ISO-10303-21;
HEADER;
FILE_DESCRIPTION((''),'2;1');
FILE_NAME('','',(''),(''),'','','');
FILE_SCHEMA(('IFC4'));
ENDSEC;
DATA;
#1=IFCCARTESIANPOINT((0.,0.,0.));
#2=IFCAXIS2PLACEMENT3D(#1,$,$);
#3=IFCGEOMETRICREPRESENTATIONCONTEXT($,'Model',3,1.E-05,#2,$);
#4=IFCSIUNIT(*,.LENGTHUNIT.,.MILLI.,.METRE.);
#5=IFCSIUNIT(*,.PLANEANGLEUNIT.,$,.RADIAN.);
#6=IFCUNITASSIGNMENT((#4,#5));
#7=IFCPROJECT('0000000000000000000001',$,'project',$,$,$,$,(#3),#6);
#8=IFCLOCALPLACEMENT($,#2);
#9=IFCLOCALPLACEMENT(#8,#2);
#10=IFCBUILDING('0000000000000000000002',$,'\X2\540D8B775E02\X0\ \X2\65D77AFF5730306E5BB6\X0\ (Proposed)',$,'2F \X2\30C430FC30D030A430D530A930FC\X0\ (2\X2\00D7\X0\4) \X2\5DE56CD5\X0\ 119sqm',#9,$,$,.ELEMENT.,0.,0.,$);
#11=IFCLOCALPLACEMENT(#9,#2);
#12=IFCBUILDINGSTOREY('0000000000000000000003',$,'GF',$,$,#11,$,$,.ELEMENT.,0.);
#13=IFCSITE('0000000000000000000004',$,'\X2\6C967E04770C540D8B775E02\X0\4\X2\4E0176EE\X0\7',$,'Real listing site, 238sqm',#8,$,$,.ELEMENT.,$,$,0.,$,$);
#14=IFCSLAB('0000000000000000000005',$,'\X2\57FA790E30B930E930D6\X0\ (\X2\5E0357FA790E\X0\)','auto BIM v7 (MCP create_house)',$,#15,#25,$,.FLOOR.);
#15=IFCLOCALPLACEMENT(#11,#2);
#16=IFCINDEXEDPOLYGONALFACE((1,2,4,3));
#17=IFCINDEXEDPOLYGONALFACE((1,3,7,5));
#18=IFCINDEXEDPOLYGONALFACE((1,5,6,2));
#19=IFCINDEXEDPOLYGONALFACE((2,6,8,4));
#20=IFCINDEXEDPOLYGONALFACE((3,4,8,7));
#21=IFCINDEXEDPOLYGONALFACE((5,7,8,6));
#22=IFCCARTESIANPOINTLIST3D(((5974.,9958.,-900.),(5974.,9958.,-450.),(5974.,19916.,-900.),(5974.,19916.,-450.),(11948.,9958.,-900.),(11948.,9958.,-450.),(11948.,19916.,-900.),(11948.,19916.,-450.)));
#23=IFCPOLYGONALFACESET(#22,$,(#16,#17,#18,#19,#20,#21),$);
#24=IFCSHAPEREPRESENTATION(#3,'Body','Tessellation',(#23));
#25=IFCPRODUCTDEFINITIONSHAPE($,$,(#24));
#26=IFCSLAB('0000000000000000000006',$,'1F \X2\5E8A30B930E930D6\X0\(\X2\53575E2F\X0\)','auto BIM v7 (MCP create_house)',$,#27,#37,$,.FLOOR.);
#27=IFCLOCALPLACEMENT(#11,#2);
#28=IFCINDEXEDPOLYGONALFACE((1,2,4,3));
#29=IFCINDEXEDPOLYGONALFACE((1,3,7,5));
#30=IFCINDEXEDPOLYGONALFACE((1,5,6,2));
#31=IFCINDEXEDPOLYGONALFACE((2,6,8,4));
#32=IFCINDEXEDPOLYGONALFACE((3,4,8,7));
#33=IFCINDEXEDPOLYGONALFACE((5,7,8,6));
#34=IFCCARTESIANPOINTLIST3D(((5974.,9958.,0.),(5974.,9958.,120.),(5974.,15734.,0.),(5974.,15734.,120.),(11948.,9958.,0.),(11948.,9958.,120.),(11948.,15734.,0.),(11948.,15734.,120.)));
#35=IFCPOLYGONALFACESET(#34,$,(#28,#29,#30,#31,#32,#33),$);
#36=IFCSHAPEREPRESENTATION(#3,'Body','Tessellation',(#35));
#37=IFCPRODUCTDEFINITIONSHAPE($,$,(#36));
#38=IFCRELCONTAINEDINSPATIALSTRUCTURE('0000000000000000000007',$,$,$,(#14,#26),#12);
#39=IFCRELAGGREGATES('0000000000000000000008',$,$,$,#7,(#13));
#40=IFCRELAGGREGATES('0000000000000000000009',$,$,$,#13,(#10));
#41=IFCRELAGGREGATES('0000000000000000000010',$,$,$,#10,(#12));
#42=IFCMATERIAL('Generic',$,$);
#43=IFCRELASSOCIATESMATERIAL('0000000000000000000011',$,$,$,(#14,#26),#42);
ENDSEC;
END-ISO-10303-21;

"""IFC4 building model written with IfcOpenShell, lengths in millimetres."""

from ifc_helpers import new_model, si_unit, frame, frame_2d, origin, place, context, project, spatial, rectangle, extrude, material, element, save


model = new_model("IFC4")

# Units and contexts
model_context = context("Model", 3, precision=1e-05, world=origin())
ifc_project = project(units=[si_unit("LENGTHUNIT", "METRE", prefix="MILLI"), si_unit("PLANEANGLEUNIT", "RADIAN")], contexts=[model_context])

# Site, building, storey
site_placement = place(None, origin())
site = spatial("IfcSite", under=ifc_project, at=site_placement, Name="沖縄県名護市4丁目7", ObjectType="Real listing site, 238sqm", CompositionType="ELEMENT", RefElevation=0.0)
building_placement = place(site_placement, origin())
building = spatial("IfcBuilding", under=site, at=building_placement, Name="名護市 旗竿地の家 (Proposed)", ObjectType="2F ツーバイフォー (2×4) 工法 119sqm", CompositionType="ELEMENT", ElevationOfRefHeight=0.0, ElevationOfTerrain=0.0)
storey_placement = place(building_placement, origin())
storey = spatial("IfcBuildingStorey", under=building, at=storey_placement, Name="GF", CompositionType="ELEMENT", Elevation=0.0)

# Slabs
ifc_material = material(Name="Generic")
slab_1_placement = place(storey_placement, frame((2987.0, 4979.0, -450.0)))
element("IfcSlab", 1, at=slab_1_placement, inside=storey, material=ifc_material, Name="基礎スラブ (布基礎)", Description="auto BIM v7 (MCP create_house)", PredefinedType="FLOOR", context=model_context, shape_type="SweptSolid", body=[
    extrude(rectangle(XDim=5974.0, YDim=9958.0, at=frame_2d((2987.0, 4979.0))), frame((2987.0, 4979.0, -450.0)), (0.0, 0.0, 1.0), 450.0),
])
slab_2_placement = place(storey_placement, frame((2987.0, 4979.0, 0.0)))
element("IfcSlab", 2, at=slab_2_placement, inside=storey, material=ifc_material, Name="1F 床スラブ(南帯)", Description="auto BIM v7 (MCP create_house)", PredefinedType="FLOOR", context=model_context, shape_type="SweptSolid", body=[
    extrude(rectangle(XDim=5974.0, YDim=5776.0, at=frame_2d((2987.0, 2888.0))), frame((2987.0, 4979.0, 0.0)), (0.0, 0.0, 1.0), 120.0),
])

save(model, "model.ifc")
